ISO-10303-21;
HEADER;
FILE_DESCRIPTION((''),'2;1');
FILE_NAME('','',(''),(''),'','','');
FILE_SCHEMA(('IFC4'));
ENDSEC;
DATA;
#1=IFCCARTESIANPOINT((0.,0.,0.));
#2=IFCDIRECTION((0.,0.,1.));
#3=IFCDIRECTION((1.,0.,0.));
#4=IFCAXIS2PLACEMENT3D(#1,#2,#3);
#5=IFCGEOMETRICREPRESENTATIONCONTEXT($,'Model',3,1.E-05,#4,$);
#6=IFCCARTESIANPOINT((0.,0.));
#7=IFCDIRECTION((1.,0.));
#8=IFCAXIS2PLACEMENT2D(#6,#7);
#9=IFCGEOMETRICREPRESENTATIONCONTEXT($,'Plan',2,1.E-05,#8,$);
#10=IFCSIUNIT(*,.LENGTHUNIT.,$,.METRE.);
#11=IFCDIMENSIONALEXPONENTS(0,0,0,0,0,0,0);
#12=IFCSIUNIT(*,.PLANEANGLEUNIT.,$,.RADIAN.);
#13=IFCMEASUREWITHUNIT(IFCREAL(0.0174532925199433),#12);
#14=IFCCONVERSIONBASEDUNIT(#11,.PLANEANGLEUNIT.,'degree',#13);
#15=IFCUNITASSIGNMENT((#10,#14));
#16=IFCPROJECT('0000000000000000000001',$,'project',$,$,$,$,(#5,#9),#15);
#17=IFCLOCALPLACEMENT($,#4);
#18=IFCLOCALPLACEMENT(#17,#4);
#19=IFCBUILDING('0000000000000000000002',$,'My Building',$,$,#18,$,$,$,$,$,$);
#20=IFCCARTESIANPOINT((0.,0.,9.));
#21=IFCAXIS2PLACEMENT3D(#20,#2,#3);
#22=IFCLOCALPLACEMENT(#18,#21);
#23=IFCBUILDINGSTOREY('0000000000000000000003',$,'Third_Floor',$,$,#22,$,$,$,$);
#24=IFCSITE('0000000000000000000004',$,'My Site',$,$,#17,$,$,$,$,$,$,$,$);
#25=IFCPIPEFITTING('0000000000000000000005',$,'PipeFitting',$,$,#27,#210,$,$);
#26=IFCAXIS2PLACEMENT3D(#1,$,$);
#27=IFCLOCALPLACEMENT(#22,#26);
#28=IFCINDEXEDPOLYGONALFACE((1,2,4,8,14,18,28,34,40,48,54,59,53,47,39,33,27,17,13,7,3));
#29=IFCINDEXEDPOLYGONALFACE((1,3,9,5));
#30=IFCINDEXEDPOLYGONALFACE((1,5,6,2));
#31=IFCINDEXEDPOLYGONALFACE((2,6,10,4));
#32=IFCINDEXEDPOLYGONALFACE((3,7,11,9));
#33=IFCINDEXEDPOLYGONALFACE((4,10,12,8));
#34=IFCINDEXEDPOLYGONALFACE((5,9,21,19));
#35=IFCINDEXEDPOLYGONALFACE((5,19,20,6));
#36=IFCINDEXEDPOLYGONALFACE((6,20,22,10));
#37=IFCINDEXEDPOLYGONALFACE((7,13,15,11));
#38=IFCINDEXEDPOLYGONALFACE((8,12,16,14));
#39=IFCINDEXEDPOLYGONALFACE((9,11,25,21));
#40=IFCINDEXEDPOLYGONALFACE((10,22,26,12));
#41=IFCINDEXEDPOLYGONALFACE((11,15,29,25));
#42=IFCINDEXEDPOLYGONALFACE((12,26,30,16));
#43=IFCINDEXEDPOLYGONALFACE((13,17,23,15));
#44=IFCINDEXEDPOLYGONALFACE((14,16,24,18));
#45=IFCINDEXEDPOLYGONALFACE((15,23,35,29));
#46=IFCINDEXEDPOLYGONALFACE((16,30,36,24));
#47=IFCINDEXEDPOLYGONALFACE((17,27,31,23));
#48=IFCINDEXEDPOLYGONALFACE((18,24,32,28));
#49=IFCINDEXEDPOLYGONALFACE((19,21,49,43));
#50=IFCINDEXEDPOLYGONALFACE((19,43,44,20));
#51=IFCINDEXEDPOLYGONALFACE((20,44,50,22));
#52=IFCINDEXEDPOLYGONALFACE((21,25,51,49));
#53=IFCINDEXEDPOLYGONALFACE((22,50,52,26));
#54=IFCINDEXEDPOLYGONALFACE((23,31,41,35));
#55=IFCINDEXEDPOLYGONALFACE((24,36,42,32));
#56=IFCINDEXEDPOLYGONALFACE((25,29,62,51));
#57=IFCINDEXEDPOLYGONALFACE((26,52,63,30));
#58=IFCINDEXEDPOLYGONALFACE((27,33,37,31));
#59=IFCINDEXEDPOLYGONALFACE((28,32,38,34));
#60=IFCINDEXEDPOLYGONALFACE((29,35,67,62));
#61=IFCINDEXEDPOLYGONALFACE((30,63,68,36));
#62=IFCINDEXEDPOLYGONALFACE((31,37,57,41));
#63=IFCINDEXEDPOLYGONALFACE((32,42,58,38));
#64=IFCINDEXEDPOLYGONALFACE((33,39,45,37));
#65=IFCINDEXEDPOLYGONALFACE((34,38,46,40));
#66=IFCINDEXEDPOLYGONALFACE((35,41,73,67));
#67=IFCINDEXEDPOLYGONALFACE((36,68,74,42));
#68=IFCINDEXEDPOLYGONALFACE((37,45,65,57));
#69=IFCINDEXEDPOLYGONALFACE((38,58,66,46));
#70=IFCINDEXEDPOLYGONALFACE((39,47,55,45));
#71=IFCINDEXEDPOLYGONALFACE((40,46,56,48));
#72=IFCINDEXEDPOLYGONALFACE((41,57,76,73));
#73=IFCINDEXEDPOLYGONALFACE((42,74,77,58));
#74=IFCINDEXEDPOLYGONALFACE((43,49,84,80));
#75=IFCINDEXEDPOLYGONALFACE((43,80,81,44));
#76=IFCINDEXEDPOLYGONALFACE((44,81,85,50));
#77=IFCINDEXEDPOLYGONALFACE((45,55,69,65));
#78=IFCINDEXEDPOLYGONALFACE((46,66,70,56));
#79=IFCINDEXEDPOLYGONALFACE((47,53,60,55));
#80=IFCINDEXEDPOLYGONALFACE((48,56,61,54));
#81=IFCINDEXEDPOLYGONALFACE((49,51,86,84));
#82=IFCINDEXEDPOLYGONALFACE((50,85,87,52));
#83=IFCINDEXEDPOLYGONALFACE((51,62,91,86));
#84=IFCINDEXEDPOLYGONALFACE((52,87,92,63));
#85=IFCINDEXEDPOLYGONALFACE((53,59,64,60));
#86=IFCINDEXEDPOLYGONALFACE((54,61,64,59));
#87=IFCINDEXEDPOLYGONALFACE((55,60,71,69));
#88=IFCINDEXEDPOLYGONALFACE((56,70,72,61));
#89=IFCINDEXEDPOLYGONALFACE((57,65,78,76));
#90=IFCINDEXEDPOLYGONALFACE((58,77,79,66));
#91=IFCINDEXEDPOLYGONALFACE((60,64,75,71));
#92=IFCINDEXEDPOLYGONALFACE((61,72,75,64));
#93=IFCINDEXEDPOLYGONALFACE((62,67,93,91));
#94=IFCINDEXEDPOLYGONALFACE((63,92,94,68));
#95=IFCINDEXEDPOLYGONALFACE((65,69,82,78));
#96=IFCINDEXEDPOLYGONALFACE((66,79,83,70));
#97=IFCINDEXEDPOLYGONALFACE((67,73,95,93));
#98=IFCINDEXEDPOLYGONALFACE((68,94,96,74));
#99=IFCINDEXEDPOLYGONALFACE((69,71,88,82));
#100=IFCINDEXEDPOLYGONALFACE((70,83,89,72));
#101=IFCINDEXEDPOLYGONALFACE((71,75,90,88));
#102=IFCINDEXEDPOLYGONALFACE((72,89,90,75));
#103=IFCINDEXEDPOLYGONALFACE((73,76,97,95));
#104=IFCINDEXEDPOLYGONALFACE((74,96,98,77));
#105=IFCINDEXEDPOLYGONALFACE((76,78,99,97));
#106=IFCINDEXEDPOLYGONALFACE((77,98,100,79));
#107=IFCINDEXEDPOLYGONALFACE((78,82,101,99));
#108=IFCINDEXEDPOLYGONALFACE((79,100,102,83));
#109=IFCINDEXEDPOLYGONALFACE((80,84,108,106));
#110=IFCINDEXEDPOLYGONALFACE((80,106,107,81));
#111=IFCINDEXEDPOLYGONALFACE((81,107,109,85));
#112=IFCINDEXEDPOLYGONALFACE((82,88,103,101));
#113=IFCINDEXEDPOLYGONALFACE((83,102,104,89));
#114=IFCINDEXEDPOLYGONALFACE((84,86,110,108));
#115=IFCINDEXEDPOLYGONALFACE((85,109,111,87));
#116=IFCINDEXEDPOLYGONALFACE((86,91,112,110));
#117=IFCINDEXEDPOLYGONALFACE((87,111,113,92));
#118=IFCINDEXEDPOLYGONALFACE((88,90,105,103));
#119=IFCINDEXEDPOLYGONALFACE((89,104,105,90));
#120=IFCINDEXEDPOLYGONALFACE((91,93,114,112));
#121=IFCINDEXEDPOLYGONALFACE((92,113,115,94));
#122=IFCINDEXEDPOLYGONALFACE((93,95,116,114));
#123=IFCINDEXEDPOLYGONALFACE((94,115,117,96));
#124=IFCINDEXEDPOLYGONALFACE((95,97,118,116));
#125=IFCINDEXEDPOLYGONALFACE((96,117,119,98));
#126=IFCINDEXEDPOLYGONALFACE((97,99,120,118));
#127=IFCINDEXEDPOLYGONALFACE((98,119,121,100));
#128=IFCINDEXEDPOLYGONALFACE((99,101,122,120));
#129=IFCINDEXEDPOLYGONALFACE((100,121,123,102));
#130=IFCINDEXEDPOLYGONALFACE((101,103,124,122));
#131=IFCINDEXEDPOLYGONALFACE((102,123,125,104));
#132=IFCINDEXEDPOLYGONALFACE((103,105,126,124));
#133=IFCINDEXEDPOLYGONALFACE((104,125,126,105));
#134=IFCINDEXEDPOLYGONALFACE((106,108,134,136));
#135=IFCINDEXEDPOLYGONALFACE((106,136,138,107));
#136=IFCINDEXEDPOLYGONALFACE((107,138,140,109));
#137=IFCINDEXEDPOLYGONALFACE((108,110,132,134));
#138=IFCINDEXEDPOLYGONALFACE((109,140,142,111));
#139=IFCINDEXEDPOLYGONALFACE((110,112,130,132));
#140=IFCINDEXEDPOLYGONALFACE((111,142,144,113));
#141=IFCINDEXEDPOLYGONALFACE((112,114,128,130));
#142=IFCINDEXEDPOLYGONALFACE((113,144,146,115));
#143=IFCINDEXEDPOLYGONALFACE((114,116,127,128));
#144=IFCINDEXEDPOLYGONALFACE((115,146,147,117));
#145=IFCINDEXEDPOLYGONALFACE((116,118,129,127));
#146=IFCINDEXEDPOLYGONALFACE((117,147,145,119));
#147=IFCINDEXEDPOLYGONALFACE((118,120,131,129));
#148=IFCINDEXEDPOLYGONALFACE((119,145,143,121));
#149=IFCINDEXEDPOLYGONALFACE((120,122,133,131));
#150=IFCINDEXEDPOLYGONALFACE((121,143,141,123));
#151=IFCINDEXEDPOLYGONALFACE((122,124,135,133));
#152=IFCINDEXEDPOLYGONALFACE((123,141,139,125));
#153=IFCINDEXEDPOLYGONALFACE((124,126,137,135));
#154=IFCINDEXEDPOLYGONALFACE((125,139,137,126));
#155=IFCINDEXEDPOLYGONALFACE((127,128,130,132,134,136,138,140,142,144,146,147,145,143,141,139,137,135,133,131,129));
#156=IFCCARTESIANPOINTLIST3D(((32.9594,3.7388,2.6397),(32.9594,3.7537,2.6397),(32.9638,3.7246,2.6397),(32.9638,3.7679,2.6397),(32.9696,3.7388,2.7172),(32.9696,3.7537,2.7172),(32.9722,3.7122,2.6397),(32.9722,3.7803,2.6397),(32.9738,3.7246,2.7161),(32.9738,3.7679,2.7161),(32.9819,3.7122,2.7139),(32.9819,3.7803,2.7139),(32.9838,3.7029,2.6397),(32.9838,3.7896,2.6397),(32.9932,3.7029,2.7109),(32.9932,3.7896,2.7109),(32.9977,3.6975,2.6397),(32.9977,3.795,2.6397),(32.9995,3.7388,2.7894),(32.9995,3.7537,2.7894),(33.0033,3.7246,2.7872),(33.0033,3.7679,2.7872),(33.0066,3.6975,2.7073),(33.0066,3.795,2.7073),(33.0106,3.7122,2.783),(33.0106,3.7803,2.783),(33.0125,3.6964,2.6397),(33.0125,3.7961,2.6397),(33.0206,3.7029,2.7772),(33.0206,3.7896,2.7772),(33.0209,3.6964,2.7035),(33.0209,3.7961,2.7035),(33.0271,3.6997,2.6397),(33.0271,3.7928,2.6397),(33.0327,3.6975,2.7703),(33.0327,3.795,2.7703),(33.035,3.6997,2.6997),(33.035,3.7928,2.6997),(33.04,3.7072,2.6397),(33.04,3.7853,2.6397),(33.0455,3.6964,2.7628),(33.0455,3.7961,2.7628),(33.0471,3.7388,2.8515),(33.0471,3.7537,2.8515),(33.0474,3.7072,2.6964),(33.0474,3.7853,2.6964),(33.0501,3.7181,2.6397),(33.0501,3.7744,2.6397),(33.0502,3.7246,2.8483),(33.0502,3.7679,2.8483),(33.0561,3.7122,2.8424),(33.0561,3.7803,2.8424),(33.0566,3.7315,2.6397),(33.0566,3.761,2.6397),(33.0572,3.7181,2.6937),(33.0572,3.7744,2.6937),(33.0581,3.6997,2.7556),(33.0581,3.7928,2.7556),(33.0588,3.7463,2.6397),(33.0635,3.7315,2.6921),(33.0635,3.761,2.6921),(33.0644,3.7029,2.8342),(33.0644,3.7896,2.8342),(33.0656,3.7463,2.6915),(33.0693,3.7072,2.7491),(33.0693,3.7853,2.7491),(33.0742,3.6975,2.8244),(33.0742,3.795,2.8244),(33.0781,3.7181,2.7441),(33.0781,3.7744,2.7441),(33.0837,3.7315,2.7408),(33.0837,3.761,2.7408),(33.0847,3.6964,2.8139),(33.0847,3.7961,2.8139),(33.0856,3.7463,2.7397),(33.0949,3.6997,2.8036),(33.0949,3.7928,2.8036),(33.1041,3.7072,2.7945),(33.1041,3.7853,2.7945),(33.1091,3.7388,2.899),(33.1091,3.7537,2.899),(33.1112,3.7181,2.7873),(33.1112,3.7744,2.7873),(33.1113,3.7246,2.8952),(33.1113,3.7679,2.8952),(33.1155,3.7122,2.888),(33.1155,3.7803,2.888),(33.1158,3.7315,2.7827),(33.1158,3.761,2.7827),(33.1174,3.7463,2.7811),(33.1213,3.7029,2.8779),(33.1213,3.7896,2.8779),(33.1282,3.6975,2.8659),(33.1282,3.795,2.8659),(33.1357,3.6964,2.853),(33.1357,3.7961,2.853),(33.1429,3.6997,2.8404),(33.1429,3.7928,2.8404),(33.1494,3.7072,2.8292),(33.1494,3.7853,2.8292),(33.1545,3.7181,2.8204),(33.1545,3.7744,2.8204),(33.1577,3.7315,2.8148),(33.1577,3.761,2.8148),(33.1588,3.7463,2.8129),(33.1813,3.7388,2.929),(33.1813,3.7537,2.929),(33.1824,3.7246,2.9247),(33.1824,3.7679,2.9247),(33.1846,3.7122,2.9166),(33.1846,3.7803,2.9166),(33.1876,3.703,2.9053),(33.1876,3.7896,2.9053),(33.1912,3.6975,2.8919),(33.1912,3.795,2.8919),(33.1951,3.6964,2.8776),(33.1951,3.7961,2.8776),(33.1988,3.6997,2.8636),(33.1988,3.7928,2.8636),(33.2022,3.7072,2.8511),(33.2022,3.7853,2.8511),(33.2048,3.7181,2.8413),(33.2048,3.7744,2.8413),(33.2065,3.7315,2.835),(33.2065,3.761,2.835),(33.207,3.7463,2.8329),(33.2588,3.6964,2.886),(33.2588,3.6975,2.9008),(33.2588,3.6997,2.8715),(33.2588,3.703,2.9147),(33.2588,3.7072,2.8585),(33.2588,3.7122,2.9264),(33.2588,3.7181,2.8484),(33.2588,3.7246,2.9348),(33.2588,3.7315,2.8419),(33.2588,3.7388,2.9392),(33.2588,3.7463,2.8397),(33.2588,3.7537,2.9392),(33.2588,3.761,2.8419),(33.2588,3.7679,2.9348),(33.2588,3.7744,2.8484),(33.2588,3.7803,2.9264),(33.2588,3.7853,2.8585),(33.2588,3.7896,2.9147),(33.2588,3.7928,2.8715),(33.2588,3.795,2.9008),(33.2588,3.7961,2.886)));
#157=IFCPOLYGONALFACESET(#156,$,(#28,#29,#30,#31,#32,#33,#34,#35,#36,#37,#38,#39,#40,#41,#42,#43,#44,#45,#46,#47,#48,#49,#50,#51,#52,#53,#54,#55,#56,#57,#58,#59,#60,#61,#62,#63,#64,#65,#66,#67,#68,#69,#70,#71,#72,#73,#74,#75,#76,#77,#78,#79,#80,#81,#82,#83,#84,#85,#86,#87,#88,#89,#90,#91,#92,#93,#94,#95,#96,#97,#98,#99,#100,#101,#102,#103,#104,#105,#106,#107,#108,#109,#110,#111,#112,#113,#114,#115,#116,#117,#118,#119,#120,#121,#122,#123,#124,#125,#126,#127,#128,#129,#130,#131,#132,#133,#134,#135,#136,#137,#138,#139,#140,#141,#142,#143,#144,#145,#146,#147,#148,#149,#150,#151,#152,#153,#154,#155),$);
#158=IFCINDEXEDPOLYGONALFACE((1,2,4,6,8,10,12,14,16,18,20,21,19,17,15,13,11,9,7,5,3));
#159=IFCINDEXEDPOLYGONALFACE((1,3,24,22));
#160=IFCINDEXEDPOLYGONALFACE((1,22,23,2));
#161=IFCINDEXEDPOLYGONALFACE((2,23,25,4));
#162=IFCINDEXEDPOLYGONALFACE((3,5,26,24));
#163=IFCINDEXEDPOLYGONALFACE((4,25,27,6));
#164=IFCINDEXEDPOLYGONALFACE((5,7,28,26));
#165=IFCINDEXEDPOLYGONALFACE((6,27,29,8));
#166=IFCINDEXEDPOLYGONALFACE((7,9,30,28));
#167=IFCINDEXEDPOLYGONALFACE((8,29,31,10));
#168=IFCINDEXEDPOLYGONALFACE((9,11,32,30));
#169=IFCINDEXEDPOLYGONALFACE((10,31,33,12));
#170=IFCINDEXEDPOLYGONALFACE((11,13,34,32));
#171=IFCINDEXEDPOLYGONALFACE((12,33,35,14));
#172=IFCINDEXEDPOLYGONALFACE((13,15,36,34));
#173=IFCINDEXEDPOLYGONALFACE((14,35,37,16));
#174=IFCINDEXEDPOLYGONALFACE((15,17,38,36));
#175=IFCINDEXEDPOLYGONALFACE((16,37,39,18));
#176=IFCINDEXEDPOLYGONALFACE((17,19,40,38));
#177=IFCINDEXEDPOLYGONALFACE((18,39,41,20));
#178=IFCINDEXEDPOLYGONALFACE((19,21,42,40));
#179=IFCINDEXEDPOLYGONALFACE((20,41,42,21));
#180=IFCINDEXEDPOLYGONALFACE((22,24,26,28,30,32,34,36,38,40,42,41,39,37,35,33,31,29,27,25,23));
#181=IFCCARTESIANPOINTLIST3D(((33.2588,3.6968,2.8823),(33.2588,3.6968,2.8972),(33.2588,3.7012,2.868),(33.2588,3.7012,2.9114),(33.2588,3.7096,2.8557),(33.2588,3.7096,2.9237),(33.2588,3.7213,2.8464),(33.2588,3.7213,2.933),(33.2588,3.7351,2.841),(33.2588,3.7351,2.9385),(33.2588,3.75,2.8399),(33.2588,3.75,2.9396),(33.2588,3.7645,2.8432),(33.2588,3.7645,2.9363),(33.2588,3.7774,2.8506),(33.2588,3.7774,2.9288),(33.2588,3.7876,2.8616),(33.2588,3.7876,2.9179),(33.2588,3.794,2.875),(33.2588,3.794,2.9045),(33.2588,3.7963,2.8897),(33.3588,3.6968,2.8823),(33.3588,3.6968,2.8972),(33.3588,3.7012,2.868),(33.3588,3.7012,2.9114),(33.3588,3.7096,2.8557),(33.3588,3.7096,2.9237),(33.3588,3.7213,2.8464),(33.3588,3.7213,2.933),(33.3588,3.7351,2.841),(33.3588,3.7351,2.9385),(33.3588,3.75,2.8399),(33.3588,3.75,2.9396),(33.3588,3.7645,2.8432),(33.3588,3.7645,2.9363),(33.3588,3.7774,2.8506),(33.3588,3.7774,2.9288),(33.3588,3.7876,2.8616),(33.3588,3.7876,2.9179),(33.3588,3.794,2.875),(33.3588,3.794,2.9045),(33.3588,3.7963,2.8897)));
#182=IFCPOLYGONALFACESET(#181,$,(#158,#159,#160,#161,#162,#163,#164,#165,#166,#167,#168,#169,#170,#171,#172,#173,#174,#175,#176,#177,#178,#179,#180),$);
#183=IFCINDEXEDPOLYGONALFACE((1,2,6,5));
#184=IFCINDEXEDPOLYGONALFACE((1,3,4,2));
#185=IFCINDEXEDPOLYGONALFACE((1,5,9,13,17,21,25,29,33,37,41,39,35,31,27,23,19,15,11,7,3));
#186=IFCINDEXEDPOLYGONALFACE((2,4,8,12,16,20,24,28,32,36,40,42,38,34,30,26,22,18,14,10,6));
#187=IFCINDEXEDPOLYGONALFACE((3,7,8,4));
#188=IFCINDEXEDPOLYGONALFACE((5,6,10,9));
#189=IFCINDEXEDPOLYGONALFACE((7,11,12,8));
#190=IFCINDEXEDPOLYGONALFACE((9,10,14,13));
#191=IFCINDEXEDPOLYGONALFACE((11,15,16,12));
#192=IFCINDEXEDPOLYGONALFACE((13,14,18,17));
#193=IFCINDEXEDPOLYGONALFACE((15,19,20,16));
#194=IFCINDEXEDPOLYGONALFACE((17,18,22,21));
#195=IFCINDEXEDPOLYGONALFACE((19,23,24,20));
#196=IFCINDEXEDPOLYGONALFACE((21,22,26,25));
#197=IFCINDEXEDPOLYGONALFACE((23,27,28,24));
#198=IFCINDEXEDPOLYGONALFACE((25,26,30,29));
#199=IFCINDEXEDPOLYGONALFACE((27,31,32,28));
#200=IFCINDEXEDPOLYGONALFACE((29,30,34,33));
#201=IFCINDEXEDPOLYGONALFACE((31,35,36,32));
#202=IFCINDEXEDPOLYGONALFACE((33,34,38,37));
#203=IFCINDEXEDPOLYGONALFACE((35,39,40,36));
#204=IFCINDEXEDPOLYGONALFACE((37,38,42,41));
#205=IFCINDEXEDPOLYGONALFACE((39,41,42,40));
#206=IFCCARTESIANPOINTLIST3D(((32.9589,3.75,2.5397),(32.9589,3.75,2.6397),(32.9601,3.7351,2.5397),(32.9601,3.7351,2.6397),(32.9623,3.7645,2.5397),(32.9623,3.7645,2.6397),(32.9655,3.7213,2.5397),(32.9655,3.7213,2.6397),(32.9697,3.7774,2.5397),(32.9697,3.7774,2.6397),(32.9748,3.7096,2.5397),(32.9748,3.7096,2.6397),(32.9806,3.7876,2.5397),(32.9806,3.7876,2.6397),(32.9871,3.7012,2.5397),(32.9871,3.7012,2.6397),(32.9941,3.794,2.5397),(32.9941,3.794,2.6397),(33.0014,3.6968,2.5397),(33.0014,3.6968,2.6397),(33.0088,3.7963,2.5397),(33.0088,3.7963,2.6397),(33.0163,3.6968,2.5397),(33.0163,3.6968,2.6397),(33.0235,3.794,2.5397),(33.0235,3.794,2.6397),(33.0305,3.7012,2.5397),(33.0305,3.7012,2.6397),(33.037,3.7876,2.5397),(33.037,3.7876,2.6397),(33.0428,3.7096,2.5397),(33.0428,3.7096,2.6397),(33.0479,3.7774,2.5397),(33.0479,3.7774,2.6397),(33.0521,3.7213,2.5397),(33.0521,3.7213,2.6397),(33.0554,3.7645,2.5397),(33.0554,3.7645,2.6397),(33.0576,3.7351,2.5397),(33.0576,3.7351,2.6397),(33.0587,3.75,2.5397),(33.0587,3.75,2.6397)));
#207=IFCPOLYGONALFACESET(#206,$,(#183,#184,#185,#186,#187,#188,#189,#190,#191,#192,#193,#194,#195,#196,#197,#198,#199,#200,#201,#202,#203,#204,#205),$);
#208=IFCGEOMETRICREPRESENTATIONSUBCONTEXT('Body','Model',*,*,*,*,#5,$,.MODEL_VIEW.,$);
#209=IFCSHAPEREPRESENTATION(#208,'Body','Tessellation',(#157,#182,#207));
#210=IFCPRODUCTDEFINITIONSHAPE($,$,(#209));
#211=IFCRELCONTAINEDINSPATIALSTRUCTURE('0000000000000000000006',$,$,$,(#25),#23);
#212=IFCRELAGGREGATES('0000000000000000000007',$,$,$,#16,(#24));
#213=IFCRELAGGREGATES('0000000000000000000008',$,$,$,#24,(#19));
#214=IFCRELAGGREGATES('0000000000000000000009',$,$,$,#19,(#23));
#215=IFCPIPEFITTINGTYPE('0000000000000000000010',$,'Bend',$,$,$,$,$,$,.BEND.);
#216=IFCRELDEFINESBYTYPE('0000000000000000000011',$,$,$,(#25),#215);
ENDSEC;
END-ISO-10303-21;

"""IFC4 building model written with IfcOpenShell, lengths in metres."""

from ifc_helpers import new_model, entity, si_unit, converted_unit, frame, origin_with_axes, origin_2d_with_axis, place, context, subcontext, project, spatial, circle, extrude, source, transform, mapped, type_object, type_shapes, element, save


model = new_model("IFC4")

# Units and contexts
model_context = context("Model", 3, precision=1e-05, world=origin_with_axes())
plan_context = context("Plan", 2, precision=1e-05, world=origin_2d_with_axis())
body_context_1 = subcontext(model_context, "Body", "Model", "MODEL_VIEW")
ifc_project = project(units=[si_unit("LENGTHUNIT", "METRE"), converted_unit("PLANEANGLEUNIT", "degree", entity("IfcReal", 0.0174532925199433), si_unit("PLANEANGLEUNIT", "RADIAN"), dimensions=[0, 0, 0, 0, 0, 0, 0])], contexts=[model_context, plan_context])

# Site, building, storey
site_placement = place(None, origin_with_axes())
site = spatial("IfcSite", under=ifc_project, at=site_placement, Name="My Site")
building_placement = place(site_placement, origin_with_axes())
building = spatial("IfcBuilding", under=site, at=building_placement, Name="My Building")
storey_placement = place(building_placement, frame((0.0, 0.0, 9.0), z_axis=(0.0, 0.0, 1.0), x_axis=(1.0, 0.0, 0.0)))
storey = spatial("IfcBuildingStorey", under=building, at=storey_placement, Name="Third_Floor")

# Pipe fitting
pipe_fitting_type = type_object("IfcPipeFittingType", Name="Bend", PredefinedType="BEND")
shared_shape_1 = source(origin_with_axes(), body_context_1, "Body", "SolidModel", [
    entity("IfcSweptDiskSolid", entity("IfcIndexedPolyCurve", entity("IfcCartesianPointList3D", [[0.0, 0.0, -0.1], [0.0, -0.0732, -0.2768], [0.0, -0.25, -0.35]]), [entity("IfcArcIndex", [1, 2, 3])]), 0.05),
    extrude(circle(Radius=0.05), origin_with_axes(), (0.0, 0.0, -1.0), 0.1),
    extrude(circle(Radius=0.05), frame((0.0, -0.25, -0.35), z_axis=(0.0, -1.0, 0.0), x_axis=(1.0, 0.0, 0.0)), (0.0, 0.0, 1.0), 0.1),
])
type_shapes(pipe_fitting_type, [shared_shape_1])
for number, where, z_axis, x_axis, name in (
    (1, (33.3588, 3.7463, 2.8897), (1.0, 0.0, 0.0), (0.0, 1.0, 0.0), "PipeFitting"),
):
    element("IfcPipeFitting", number, at=place(storey_placement, frame(where, z_axis=z_axis, x_axis=x_axis)), inside=storey, type_object=pipe_fitting_type, Name=name, context=body_context_1, shape_type="MappedRepresentation", body=[
        mapped(shared_shape_1, transform((0.0, 0.0, 0.0), x_axis=(1.0, 0.0, 0.0), y_axis=(0.0, 1.0, 0.0), z_axis=(0.0, 0.0, 1.0), scale=1.0)),
    ])

save(model, "model.ifc")
